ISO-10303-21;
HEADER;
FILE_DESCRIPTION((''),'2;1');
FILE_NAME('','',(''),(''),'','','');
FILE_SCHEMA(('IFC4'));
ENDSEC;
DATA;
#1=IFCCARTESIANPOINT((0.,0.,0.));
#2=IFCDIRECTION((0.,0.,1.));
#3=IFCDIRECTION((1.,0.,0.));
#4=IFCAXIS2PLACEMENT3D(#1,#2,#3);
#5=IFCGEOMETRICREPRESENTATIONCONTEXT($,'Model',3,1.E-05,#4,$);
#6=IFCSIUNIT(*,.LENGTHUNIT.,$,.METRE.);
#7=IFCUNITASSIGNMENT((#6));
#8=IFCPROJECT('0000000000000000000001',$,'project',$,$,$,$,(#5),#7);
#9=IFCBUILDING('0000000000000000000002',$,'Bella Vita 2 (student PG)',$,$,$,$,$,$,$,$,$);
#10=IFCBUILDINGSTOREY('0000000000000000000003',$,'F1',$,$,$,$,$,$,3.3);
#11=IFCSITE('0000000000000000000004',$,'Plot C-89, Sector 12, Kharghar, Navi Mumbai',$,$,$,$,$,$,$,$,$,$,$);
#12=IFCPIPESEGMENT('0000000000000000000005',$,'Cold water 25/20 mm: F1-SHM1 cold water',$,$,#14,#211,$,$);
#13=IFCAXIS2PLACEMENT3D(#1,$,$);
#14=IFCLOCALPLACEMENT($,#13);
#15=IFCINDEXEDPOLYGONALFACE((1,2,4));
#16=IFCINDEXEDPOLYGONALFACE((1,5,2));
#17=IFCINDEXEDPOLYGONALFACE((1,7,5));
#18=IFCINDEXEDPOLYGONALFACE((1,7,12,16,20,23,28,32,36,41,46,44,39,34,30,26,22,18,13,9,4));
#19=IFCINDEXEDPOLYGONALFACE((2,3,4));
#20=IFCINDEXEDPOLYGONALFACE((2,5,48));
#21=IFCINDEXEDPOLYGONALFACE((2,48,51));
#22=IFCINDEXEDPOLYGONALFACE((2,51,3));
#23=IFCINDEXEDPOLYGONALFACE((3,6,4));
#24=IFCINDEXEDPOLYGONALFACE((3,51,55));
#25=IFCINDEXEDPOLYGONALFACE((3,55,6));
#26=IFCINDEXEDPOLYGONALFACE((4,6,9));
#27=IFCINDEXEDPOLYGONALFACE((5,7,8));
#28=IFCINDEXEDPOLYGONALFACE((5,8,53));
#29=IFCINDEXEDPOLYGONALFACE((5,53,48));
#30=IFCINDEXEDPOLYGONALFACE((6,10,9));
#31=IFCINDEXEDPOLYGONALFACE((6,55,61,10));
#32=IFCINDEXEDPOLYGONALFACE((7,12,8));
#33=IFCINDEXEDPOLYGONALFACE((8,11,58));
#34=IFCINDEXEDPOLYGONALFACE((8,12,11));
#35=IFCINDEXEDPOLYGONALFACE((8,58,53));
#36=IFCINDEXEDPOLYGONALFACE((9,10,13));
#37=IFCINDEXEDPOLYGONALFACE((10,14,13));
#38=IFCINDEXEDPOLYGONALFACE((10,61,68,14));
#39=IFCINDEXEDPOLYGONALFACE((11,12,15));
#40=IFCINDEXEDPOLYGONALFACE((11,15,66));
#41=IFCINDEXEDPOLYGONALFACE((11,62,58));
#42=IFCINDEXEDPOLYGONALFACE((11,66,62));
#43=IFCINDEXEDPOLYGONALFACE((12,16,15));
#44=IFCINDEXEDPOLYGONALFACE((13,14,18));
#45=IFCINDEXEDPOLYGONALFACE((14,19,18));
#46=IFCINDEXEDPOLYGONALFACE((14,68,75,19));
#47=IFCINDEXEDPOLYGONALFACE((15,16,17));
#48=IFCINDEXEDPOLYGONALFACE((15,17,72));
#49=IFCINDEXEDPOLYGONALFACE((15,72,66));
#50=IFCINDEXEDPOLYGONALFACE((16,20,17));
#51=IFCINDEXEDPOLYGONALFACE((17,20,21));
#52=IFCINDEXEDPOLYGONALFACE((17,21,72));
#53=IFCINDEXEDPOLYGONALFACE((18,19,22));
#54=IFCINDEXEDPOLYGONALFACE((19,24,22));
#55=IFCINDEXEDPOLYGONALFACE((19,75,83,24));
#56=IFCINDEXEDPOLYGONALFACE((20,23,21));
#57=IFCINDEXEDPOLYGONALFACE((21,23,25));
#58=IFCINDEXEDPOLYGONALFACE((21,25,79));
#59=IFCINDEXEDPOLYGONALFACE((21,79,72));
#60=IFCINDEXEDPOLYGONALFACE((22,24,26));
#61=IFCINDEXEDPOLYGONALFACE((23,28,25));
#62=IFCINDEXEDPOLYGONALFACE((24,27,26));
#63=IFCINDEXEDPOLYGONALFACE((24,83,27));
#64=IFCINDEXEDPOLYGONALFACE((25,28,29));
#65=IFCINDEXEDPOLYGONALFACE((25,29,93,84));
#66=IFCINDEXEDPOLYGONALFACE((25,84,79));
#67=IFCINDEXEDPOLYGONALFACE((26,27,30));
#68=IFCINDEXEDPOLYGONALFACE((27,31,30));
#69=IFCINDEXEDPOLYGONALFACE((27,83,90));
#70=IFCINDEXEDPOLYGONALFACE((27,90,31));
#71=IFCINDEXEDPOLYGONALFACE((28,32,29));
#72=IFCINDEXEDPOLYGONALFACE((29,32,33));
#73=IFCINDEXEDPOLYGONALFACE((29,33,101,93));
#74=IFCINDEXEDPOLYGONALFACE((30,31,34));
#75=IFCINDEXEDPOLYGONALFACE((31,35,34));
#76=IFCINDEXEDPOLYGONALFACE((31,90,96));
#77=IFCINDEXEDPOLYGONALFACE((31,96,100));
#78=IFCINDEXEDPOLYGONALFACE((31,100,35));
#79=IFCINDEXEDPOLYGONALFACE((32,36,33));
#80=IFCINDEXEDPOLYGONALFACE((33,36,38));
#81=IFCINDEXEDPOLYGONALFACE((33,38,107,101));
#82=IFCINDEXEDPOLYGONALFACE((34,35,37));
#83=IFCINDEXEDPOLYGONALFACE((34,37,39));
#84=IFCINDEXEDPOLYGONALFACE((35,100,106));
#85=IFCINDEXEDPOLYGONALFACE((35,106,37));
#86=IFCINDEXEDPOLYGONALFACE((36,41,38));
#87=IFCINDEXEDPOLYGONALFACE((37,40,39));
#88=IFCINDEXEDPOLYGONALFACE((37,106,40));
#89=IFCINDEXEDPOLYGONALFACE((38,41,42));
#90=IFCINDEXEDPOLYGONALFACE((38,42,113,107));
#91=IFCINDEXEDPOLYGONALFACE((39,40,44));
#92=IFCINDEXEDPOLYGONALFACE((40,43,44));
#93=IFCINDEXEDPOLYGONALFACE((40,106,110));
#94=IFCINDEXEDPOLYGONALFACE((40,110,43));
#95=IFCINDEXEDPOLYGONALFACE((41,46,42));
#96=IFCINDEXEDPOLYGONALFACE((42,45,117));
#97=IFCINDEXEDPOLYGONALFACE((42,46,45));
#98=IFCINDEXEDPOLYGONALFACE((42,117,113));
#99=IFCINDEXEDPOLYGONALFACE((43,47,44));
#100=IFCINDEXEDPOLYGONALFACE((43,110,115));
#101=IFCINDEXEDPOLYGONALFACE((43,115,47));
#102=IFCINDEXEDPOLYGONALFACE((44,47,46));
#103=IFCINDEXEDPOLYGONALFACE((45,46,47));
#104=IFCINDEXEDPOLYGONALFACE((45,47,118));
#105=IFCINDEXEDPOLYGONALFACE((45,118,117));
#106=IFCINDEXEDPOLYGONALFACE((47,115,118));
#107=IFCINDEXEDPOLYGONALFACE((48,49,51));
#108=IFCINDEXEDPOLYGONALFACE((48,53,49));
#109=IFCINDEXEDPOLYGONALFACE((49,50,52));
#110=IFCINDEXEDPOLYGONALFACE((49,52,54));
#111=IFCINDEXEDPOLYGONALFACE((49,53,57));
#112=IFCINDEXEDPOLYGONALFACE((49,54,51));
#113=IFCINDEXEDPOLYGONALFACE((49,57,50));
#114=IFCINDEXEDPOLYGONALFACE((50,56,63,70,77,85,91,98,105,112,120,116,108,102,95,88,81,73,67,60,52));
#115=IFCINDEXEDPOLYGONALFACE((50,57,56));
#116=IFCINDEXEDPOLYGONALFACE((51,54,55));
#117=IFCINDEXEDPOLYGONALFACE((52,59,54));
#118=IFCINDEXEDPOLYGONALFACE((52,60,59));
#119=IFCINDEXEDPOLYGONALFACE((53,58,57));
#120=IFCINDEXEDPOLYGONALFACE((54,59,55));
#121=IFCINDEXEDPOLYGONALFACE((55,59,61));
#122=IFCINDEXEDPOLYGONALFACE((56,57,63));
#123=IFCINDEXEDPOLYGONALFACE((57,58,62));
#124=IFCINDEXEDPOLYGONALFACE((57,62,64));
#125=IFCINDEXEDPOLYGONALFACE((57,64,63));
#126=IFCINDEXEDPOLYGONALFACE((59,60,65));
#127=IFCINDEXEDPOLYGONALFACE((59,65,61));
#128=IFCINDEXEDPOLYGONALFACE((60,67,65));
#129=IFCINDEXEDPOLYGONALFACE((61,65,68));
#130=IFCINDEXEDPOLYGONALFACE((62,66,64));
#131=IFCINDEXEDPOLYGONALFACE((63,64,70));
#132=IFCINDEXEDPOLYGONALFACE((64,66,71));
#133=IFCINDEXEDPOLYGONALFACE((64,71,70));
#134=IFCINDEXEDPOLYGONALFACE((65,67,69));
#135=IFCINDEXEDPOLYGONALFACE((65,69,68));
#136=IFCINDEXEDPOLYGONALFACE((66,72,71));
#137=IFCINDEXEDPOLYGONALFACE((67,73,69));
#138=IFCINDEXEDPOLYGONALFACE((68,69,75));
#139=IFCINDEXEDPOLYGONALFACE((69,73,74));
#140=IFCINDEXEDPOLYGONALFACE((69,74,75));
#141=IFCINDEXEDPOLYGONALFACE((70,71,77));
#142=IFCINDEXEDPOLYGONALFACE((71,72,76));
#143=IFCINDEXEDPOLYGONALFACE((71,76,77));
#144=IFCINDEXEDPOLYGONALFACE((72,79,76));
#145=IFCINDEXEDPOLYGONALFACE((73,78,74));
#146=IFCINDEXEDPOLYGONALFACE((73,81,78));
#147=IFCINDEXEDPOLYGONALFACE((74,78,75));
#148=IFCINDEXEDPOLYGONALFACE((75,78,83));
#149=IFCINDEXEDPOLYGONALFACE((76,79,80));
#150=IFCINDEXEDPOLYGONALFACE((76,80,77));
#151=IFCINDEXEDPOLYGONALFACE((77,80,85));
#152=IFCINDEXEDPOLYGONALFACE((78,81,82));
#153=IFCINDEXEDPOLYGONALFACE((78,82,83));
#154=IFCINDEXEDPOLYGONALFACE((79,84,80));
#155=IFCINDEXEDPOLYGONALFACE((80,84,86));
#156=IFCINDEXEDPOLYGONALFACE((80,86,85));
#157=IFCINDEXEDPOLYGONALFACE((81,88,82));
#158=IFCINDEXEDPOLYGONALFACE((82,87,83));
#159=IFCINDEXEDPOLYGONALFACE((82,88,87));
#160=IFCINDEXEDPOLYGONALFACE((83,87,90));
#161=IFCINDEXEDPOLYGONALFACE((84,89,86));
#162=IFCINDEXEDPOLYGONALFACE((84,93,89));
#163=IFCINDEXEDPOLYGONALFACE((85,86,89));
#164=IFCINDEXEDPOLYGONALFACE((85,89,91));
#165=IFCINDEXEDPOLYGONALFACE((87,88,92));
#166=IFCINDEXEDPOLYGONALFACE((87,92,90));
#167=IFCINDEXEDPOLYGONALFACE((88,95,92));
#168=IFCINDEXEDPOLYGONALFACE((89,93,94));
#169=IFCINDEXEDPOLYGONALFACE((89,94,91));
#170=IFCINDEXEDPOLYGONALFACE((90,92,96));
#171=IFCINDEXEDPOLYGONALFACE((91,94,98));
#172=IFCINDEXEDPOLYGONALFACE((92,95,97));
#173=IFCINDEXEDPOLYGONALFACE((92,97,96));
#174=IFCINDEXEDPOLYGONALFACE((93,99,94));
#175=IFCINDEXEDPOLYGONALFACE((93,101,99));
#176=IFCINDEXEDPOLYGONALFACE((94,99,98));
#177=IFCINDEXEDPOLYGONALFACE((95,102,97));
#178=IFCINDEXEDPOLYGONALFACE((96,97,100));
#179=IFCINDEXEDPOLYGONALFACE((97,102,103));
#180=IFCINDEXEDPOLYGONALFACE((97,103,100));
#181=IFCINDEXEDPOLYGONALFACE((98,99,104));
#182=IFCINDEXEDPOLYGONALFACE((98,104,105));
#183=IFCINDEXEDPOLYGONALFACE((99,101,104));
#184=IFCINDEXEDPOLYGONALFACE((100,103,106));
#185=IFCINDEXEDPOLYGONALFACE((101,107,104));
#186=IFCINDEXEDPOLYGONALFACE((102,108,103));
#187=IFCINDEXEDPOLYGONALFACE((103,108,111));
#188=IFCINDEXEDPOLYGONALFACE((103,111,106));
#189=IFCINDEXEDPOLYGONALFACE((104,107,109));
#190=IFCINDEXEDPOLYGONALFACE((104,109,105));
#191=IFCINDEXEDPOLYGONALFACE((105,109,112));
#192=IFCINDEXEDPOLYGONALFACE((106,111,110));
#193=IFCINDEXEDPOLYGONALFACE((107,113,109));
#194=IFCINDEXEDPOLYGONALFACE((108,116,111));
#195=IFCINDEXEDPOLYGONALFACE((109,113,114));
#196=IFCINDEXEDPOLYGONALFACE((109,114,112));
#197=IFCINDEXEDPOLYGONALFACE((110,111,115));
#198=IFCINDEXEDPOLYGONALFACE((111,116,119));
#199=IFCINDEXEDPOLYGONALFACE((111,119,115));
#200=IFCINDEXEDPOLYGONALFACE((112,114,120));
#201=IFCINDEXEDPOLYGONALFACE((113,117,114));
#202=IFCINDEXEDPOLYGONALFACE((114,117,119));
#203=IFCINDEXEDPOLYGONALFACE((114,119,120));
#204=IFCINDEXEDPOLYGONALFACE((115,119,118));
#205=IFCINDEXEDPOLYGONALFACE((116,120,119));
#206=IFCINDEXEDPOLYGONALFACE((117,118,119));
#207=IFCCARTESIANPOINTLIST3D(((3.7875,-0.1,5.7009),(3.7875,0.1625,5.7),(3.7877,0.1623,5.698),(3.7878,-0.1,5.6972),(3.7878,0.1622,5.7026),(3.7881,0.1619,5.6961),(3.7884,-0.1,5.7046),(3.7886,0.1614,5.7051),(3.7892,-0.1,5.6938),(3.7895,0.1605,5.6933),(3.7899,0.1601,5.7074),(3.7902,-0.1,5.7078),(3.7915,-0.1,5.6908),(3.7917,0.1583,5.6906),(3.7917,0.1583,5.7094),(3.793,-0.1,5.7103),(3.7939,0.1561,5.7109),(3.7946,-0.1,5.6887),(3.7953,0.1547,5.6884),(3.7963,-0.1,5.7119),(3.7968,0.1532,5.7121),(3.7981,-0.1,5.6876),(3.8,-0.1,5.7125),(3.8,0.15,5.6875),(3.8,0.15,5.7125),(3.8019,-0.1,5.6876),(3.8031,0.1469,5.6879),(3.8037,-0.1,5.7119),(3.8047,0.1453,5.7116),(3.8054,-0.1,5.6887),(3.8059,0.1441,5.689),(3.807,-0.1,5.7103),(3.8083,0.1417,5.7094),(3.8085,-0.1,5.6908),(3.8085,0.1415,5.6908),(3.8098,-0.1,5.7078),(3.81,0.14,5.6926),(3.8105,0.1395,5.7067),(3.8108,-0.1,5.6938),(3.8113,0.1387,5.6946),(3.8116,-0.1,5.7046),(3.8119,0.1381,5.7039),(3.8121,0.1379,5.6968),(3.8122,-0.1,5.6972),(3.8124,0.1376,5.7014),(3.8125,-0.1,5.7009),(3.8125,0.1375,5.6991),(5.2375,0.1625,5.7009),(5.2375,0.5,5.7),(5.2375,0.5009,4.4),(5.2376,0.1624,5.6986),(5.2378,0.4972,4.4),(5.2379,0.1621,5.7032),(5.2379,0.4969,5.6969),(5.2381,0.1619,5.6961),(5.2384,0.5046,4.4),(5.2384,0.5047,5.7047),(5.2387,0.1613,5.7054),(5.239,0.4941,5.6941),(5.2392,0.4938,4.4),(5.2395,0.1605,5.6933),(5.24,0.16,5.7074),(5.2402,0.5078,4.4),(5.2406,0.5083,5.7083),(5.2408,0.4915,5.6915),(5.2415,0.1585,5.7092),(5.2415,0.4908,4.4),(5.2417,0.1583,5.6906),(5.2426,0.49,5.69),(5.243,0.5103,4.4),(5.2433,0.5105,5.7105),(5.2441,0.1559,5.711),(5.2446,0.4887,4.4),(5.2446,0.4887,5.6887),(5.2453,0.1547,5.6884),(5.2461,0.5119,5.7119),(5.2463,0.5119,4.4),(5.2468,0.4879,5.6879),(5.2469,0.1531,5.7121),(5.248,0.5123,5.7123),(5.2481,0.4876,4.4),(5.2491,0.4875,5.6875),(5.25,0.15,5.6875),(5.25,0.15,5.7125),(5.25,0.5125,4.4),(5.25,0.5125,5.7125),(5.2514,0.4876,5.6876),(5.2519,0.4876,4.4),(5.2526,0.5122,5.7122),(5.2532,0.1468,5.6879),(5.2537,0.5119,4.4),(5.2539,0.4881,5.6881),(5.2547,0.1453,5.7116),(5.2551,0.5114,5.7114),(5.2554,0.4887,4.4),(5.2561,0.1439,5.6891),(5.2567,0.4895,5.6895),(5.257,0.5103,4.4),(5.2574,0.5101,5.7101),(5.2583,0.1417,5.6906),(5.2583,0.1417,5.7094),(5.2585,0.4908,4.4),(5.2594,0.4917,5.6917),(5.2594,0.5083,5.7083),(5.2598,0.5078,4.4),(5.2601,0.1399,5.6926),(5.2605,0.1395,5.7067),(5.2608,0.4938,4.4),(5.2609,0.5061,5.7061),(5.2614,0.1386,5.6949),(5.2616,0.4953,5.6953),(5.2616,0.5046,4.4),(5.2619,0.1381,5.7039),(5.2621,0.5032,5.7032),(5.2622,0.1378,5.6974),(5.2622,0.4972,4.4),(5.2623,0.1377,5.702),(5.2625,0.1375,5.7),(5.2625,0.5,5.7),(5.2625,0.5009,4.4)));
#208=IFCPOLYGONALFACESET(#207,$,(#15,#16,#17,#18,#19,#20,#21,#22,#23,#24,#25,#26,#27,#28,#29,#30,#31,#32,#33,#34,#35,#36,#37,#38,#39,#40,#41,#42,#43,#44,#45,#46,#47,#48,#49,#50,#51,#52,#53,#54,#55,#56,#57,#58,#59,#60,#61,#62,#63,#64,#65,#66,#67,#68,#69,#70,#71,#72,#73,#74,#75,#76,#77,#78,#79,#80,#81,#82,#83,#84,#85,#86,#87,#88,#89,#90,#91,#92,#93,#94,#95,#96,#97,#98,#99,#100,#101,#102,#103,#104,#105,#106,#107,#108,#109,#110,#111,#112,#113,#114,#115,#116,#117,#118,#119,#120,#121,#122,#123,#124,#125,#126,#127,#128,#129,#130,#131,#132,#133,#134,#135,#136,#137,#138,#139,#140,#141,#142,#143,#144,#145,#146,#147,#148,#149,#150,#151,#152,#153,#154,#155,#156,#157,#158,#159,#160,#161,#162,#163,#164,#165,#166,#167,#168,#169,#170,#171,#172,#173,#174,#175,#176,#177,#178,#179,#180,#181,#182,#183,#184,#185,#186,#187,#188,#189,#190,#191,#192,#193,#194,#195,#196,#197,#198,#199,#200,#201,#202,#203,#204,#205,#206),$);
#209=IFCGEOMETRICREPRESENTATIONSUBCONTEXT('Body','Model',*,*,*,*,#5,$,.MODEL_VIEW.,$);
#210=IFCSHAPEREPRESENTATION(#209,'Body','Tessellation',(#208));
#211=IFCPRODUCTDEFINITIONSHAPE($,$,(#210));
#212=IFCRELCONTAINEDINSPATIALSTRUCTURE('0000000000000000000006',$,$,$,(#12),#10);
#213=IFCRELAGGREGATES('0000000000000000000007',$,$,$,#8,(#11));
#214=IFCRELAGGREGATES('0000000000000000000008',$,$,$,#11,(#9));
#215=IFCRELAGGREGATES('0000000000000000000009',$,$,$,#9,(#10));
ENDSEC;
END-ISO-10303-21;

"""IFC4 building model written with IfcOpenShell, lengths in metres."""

from ifc_helpers import new_model, entity, si_unit, origin, origin_with_axes, place, context, subcontext, project, spatial, element, save


model = new_model("IFC4")

# Units and contexts
model_context = context("Model", 3, precision=1e-05, world=origin_with_axes())
body_context = subcontext(model_context, "Body", "Model", "MODEL_VIEW")
ifc_project = project(units=[si_unit("LENGTHUNIT", "METRE")], contexts=[model_context])

# Site, building, storey
site = spatial("IfcSite", under=ifc_project, Name="Plot C-89, Sector 12, Kharghar, Navi Mumbai")
building = spatial("IfcBuilding", under=site, Name="Bella Vita 2 (student PG)")
storey = spatial("IfcBuildingStorey", under=building, Name="F1", Elevation=3.3)

# Pipe segment
pipe_segment_1_placement = place(None, origin())
element("IfcPipeSegment", 1, at=pipe_segment_1_placement, inside=storey, Name="Cold water 25/20 mm: F1-SHM1 cold water", context=body_context, shape_type="AdvancedSweptSolid", body=[
    entity("IfcSweptDiskSolid", entity("IfcPolyline", [entity("IfcCartesianPoint", [3.8, -0.1, 5.7]), entity("IfcCartesianPoint", [3.8, 0.15, 5.7]), entity("IfcCartesianPoint", [5.25, 0.15, 5.7]), entity("IfcCartesianPoint", [5.25, 0.5, 5.7]), entity("IfcCartesianPoint", [5.25, 0.5, 4.4])]), 0.0125),
])

save(model, "model.ifc")
